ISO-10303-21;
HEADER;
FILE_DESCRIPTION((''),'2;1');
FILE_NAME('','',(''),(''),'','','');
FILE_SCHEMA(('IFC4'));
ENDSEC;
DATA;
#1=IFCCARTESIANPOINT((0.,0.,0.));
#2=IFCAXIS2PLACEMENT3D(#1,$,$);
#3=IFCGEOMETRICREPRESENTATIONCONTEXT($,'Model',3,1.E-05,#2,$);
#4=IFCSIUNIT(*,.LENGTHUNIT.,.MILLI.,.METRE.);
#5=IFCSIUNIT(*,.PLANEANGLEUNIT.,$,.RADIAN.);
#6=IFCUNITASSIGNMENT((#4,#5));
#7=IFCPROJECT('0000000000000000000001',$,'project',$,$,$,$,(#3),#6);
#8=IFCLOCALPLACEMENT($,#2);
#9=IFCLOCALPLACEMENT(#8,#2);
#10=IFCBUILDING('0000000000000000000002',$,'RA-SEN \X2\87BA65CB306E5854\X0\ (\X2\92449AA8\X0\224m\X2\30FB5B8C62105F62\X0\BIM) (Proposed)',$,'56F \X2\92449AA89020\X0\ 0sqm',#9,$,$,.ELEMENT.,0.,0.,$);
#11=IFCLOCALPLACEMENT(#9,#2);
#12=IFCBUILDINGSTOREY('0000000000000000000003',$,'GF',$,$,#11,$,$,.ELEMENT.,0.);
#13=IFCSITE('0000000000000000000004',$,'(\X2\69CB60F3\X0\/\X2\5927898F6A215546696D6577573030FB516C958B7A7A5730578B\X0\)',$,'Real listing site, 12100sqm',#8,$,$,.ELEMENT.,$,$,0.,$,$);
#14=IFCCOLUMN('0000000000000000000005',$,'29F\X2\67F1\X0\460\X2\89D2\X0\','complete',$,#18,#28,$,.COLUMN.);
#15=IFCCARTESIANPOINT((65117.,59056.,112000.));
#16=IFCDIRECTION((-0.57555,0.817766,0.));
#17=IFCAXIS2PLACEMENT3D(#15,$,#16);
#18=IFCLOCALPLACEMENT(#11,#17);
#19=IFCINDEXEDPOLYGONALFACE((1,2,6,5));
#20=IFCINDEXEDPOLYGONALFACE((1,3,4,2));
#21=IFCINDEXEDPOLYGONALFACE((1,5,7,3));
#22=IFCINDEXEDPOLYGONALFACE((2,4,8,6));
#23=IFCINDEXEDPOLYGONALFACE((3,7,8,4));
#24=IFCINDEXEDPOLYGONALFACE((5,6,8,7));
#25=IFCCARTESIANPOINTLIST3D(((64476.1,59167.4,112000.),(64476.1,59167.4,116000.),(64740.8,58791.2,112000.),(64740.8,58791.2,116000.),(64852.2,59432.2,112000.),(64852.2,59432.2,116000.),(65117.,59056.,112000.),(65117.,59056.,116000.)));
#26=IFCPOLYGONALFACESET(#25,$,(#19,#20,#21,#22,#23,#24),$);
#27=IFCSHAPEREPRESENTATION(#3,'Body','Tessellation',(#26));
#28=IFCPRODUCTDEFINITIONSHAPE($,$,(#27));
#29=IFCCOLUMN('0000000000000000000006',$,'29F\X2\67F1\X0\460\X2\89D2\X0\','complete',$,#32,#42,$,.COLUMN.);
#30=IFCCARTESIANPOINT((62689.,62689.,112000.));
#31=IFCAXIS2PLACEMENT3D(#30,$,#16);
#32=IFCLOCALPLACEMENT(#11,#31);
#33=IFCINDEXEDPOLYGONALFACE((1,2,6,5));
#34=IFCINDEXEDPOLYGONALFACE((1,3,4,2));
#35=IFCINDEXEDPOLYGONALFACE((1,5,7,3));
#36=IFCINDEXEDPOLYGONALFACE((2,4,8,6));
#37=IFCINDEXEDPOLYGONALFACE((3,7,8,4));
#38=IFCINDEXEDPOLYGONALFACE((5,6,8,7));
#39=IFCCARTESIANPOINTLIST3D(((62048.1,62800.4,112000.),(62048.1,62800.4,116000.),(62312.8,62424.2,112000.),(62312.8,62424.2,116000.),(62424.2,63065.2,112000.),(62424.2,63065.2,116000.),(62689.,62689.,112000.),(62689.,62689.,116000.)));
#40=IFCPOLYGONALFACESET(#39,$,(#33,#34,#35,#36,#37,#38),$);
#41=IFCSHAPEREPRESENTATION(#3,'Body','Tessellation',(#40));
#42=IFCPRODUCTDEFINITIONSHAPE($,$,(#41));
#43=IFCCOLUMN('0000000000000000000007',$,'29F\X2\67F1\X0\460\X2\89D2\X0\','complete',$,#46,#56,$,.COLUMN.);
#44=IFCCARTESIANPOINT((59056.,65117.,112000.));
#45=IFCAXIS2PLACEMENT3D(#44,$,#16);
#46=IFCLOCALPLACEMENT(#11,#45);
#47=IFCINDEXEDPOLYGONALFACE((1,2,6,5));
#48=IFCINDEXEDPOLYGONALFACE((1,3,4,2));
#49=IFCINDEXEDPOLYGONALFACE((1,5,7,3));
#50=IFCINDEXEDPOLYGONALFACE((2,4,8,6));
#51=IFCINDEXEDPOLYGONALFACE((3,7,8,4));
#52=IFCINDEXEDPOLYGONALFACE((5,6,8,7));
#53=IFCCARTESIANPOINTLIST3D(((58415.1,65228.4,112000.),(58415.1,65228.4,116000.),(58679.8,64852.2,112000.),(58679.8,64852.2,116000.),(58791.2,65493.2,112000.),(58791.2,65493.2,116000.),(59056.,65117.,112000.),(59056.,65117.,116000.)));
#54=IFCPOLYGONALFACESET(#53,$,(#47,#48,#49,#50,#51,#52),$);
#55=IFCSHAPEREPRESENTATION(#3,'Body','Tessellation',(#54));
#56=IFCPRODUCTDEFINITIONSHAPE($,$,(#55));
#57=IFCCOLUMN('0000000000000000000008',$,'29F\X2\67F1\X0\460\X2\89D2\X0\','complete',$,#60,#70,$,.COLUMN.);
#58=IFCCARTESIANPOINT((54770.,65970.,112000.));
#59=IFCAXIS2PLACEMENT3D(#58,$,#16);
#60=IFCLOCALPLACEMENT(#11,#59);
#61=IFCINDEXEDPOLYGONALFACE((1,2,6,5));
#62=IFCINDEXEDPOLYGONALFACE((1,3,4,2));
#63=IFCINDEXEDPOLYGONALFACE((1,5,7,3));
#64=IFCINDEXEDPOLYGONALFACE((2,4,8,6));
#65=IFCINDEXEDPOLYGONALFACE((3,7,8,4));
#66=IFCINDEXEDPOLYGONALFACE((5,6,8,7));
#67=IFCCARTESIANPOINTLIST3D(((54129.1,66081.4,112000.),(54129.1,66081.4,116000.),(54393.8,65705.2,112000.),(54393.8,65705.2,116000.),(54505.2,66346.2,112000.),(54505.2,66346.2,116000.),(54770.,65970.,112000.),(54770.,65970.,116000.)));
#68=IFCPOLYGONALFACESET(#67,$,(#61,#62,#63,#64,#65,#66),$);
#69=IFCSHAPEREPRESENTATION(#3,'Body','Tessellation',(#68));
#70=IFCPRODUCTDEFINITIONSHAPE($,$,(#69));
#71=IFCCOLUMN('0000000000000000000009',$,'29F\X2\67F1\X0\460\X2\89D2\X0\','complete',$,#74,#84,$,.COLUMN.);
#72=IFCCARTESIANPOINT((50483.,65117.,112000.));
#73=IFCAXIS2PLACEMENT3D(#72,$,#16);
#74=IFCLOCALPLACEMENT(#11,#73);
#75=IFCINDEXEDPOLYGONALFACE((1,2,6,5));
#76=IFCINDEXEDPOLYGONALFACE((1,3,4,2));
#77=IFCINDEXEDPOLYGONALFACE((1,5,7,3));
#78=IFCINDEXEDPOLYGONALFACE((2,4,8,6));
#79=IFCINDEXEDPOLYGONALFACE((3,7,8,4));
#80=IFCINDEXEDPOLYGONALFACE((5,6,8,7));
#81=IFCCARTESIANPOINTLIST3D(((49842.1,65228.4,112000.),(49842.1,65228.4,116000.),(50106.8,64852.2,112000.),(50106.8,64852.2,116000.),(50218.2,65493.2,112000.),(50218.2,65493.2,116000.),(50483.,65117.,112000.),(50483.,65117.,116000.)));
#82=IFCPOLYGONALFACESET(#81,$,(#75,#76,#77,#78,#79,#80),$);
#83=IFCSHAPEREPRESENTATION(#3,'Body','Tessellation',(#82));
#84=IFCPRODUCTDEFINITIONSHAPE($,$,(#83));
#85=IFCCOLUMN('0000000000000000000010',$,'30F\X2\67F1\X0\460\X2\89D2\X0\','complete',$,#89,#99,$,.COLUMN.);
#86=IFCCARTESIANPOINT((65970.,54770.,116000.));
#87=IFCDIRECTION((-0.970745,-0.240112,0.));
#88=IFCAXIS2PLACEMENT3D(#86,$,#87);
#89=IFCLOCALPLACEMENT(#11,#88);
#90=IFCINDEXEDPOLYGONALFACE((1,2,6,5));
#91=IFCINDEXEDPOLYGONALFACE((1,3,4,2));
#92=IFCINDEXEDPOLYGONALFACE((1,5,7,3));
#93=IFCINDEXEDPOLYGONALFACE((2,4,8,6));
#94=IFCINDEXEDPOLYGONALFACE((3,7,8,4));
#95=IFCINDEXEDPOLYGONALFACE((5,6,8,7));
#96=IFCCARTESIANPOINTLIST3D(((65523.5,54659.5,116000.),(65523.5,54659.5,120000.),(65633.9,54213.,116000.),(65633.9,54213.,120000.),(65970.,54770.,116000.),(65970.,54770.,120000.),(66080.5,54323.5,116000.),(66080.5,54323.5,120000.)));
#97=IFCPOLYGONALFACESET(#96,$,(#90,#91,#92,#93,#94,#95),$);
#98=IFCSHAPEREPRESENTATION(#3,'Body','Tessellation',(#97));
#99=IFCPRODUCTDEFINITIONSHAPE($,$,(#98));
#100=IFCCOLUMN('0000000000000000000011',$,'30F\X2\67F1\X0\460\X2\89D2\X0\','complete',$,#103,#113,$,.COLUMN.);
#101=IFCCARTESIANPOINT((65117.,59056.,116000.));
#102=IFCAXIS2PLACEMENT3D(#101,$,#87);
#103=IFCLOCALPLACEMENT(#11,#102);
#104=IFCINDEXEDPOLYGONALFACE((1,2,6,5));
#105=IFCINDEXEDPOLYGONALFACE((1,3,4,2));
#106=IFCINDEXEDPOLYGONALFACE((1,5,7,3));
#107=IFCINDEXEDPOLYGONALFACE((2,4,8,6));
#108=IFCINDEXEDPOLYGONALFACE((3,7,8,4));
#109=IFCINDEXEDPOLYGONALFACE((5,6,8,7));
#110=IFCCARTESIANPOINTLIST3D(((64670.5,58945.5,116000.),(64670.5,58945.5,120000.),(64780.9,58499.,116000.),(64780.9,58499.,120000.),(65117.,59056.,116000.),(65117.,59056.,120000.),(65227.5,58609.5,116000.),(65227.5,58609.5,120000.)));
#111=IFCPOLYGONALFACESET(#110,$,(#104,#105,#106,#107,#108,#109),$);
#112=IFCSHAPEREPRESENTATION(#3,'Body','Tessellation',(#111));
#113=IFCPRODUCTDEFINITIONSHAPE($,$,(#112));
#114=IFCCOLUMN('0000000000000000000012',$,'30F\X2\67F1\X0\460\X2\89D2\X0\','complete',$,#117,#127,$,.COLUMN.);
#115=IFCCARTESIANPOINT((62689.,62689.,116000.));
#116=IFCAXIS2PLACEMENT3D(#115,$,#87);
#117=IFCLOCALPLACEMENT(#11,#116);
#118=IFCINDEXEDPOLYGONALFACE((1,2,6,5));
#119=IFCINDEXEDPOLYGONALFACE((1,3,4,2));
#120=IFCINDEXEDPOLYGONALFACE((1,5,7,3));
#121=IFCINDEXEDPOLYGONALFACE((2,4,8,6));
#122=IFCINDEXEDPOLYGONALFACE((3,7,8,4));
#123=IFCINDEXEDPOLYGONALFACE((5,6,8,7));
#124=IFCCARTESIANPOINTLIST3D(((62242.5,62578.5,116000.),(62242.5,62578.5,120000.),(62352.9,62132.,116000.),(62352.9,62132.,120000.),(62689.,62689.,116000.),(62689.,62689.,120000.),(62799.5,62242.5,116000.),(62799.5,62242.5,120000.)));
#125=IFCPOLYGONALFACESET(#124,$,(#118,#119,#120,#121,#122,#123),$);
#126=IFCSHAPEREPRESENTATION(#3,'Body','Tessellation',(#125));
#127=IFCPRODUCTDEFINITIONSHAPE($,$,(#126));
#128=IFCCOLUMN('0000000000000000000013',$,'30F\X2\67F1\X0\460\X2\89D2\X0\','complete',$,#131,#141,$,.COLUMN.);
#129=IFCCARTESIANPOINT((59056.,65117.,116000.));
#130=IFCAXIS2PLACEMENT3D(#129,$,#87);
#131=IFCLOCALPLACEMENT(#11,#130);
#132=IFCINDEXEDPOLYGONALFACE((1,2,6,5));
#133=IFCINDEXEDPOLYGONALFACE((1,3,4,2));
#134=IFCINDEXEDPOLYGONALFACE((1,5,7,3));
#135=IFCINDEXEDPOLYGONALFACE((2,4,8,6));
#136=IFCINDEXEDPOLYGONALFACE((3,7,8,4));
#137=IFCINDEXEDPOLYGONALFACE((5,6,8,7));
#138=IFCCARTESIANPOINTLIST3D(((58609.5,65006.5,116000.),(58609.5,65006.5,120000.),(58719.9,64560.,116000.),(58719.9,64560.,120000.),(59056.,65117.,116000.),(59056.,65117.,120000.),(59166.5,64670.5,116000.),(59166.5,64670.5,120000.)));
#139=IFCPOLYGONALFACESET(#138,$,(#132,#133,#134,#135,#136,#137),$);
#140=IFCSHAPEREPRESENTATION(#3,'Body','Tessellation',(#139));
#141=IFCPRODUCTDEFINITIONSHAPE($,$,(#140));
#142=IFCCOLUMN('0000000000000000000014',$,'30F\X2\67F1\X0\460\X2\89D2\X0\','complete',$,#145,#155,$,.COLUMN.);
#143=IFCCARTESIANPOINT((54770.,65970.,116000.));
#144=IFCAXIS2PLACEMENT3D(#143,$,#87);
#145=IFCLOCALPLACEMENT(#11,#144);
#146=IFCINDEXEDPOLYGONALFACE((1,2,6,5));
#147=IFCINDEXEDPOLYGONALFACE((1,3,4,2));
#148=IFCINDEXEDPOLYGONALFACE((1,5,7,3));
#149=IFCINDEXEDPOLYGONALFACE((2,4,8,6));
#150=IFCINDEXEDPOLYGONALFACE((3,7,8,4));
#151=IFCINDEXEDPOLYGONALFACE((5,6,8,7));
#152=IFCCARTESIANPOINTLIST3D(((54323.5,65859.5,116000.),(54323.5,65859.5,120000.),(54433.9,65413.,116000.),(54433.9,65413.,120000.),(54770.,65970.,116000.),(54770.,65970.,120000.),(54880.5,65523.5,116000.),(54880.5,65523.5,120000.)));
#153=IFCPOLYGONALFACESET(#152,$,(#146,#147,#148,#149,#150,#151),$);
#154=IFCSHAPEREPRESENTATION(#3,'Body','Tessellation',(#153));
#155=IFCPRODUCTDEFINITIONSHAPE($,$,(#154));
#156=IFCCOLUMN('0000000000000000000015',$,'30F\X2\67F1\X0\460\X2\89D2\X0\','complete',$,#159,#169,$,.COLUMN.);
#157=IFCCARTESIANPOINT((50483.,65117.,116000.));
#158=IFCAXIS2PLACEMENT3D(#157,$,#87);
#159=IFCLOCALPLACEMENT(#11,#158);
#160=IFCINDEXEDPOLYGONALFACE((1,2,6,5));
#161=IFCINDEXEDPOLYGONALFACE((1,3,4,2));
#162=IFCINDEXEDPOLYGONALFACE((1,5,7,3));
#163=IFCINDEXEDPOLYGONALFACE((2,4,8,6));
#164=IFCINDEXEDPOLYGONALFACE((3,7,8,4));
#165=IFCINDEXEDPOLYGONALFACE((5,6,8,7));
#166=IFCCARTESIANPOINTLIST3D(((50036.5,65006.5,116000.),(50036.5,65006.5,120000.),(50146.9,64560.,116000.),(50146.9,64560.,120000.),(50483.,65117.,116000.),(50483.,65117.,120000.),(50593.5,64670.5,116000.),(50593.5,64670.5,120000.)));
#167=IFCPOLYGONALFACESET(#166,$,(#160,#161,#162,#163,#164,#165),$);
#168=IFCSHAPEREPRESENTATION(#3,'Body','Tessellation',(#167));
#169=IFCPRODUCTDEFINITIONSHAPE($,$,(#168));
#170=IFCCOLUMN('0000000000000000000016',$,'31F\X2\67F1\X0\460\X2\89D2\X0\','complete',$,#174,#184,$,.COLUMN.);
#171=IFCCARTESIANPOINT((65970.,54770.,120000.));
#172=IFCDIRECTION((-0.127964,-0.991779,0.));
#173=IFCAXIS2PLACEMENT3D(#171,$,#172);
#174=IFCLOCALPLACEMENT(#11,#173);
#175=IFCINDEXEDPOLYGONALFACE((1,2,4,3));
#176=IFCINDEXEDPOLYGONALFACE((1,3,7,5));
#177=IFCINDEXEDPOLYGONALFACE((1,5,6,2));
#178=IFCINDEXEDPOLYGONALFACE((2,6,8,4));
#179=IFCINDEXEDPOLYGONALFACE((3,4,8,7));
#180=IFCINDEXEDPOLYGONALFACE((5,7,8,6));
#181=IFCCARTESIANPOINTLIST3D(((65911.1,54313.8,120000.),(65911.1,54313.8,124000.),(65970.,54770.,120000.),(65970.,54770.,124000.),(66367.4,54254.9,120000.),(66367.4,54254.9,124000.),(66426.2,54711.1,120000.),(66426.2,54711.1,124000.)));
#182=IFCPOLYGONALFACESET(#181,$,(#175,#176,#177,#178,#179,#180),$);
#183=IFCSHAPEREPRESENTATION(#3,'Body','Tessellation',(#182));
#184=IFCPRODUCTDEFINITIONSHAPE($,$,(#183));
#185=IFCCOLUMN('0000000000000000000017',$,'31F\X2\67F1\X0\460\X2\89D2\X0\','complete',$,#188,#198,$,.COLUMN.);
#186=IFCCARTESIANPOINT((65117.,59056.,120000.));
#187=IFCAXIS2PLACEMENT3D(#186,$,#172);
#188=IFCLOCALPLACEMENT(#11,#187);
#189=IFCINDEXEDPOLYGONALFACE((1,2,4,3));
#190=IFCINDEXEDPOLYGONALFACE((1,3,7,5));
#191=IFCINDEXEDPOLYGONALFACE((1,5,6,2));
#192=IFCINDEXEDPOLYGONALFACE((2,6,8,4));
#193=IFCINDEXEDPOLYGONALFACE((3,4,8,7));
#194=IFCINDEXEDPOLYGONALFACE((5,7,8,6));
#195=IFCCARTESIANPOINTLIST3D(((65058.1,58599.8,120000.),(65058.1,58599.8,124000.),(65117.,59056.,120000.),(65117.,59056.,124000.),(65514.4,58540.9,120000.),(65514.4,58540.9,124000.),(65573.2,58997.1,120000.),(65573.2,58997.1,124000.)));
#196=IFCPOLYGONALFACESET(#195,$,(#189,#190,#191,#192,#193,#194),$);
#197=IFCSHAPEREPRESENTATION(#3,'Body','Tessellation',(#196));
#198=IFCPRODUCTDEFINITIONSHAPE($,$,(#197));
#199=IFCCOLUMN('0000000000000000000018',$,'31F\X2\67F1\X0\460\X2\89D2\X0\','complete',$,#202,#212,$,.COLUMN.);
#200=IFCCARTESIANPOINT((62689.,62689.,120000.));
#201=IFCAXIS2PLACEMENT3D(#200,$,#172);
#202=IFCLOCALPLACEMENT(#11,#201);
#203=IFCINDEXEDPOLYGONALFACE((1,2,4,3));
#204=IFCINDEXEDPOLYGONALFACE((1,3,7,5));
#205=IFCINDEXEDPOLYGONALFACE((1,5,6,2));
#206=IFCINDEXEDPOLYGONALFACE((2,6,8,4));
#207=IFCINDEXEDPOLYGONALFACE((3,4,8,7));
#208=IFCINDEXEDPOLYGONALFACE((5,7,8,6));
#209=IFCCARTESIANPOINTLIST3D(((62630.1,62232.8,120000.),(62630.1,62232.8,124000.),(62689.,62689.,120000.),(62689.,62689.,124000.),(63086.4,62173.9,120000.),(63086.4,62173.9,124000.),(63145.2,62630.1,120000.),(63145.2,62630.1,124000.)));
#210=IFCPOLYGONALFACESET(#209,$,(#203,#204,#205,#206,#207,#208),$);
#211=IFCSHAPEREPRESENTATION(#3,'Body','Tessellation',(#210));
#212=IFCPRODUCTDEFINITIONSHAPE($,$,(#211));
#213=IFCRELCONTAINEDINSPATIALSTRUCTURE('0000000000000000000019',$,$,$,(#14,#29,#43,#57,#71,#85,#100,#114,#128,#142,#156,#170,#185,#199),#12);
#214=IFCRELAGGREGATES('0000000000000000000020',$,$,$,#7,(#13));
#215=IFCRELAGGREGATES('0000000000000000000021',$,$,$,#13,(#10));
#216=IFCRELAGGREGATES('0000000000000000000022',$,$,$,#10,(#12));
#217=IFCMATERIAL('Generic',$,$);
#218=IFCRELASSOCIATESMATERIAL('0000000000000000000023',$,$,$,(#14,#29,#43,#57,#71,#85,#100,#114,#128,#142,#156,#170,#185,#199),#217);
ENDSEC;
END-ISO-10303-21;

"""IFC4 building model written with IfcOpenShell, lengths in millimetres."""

from ifc_helpers import new_model, si_unit, frame, frame_2d, origin, place, context, project, spatial, rectangle, extrude, material, element, save


model = new_model("IFC4")

# Units and contexts
model_context = context("Model", 3, precision=1e-05, world=origin())
ifc_project = project(units=[si_unit("LENGTHUNIT", "METRE", prefix="MILLI"), si_unit("PLANEANGLEUNIT", "RADIAN")], contexts=[model_context])

# Site, building, storey
site_placement = place(None, origin())
site = spatial("IfcSite", under=ifc_project, at=site_placement, Name="(構想/大規模商業敷地・公開空地型)", ObjectType="Real listing site, 12100sqm", CompositionType="ELEMENT", RefElevation=0.0)
building_placement = place(site_placement, origin())
building = spatial("IfcBuilding", under=site, at=building_placement, Name="RA-SEN 螺旋の塔 (鉄骨224m・完成形BIM) (Proposed)", ObjectType="56F 鉄骨造 0sqm", CompositionType="ELEMENT", ElevationOfRefHeight=0.0, ElevationOfTerrain=0.0)
storey_placement = place(building_placement, origin())
storey = spatial("IfcBuildingStorey", under=building, at=storey_placement, Name="GF", CompositionType="ELEMENT", Elevation=0.0)

# Columns
ifc_material = material(Name="Generic")
column_1_placement = place(storey_placement, frame((65117.0, 59056.0, 112000.0), x_axis=(-0.57555, 0.817766, 0.0)))
element("IfcColumn", 1, at=column_1_placement, inside=storey, material=ifc_material, Name="29F柱460角", Description="complete", PredefinedType="COLUMN", context=model_context, shape_type="SweptSolid", body=[
    extrude(rectangle(XDim=460.0, YDim=460.0, at=frame_2d((230.0, 230.0))), frame((65117.0, 59056.0, 112000.0), x_axis=(-0.57555, 0.817766, 0.0)), (0.0, 0.0, 1.0), 4000.0),
])
column_2_placement = place(storey_placement, frame((62689.0, 62689.0, 112000.0), x_axis=(-0.57555, 0.817766, 0.0)))
element("IfcColumn", 2, at=column_2_placement, inside=storey, material=ifc_material, Name="29F柱460角", Description="complete", PredefinedType="COLUMN", context=model_context, shape_type="SweptSolid", body=[
    extrude(rectangle(XDim=460.0, YDim=460.0, at=frame_2d((230.0, 230.0))), frame((62689.0, 62689.0, 112000.0), x_axis=(-0.57555, 0.817766, 0.0)), (0.0, 0.0, 1.0), 4000.0),
])
column_3_placement = place(storey_placement, frame((59056.0, 65117.0, 112000.0), x_axis=(-0.57555, 0.817766, 0.0)))
element("IfcColumn", 3, at=column_3_placement, inside=storey, material=ifc_material, Name="29F柱460角", Description="complete", PredefinedType="COLUMN", context=model_context, shape_type="SweptSolid", body=[
    extrude(rectangle(XDim=460.0, YDim=460.0, at=frame_2d((230.0, 230.0))), frame((59056.0, 65117.0, 112000.0), x_axis=(-0.57555, 0.817766, 0.0)), (0.0, 0.0, 1.0), 4000.0),
])
column_4_placement = place(storey_placement, frame((54770.0, 65970.0, 112000.0), x_axis=(-0.57555, 0.817766, 0.0)))
element("IfcColumn", 4, at=column_4_placement, inside=storey, material=ifc_material, Name="29F柱460角", Description="complete", PredefinedType="COLUMN", context=model_context, shape_type="SweptSolid", body=[
    extrude(rectangle(XDim=460.0, YDim=460.0, at=frame_2d((230.0, 230.0))), frame((54770.0, 65970.0, 112000.0), x_axis=(-0.57555, 0.817766, 0.0)), (0.0, 0.0, 1.0), 4000.0),
])
column_5_placement = place(storey_placement, frame((50483.0, 65117.0, 112000.0), x_axis=(-0.57555, 0.817766, 0.0)))
element("IfcColumn", 5, at=column_5_placement, inside=storey, material=ifc_material, Name="29F柱460角", Description="complete", PredefinedType="COLUMN", context=model_context, shape_type="SweptSolid", body=[
    extrude(rectangle(XDim=460.0, YDim=460.0, at=frame_2d((230.0, 230.0))), frame((50483.0, 65117.0, 112000.0), x_axis=(-0.57555, 0.817766, 0.0)), (0.0, 0.0, 1.0), 4000.0),
])
column_6_placement = place(storey_placement, frame((65970.0, 54770.0, 116000.0), x_axis=(-0.970745, -0.240112, 0.0)))
element("IfcColumn", 6, at=column_6_placement, inside=storey, material=ifc_material, Name="30F柱460角", Description="complete", PredefinedType="COLUMN", context=model_context, shape_type="SweptSolid", body=[
    extrude(rectangle(XDim=460.0, YDim=460.0, at=frame_2d((230.0, 230.0))), frame((65970.0, 54770.0, 116000.0), x_axis=(-0.970745, -0.240112, 0.0)), (0.0, 0.0, 1.0), 4000.0),
])
column_7_placement = place(storey_placement, frame((65117.0, 59056.0, 116000.0), x_axis=(-0.970745, -0.240112, 0.0)))
element("IfcColumn", 7, at=column_7_placement, inside=storey, material=ifc_material, Name="30F柱460角", Description="complete", PredefinedType="COLUMN", context=model_context, shape_type="SweptSolid", body=[
    extrude(rectangle(XDim=460.0, YDim=460.0, at=frame_2d((230.0, 230.0))), frame((65117.0, 59056.0, 116000.0), x_axis=(-0.970745, -0.240112, 0.0)), (0.0, 0.0, 1.0), 4000.0),
])
column_8_placement = place(storey_placement, frame((62689.0, 62689.0, 116000.0), x_axis=(-0.970745, -0.240112, 0.0)))
element("IfcColumn", 8, at=column_8_placement, inside=storey, material=ifc_material, Name="30F柱460角", Description="complete", PredefinedType="COLUMN", context=model_context, shape_type="SweptSolid", body=[
    extrude(rectangle(XDim=460.0, YDim=460.0, at=frame_2d((230.0, 230.0))), frame((62689.0, 62689.0, 116000.0), x_axis=(-0.970745, -0.240112, 0.0)), (0.0, 0.0, 1.0), 4000.0),
])
column_9_placement = place(storey_placement, frame((59056.0, 65117.0, 116000.0), x_axis=(-0.970745, -0.240112, 0.0)))
element("IfcColumn", 9, at=column_9_placement, inside=storey, material=ifc_material, Name="30F柱460角", Description="complete", PredefinedType="COLUMN", context=model_context, shape_type="SweptSolid", body=[
    extrude(rectangle(XDim=460.0, YDim=460.0, at=frame_2d((230.0, 230.0))), frame((59056.0, 65117.0, 116000.0), x_axis=(-0.970745, -0.240112, 0.0)), (0.0, 0.0, 1.0), 4000.0),
])
column_10_placement = place(storey_placement, frame((54770.0, 65970.0, 116000.0), x_axis=(-0.970745, -0.240112, 0.0)))
element("IfcColumn", 10, at=column_10_placement, inside=storey, material=ifc_material, Name="30F柱460角", Description="complete", PredefinedType="COLUMN", context=model_context, shape_type="SweptSolid", body=[
    extrude(rectangle(XDim=460.0, YDim=460.0, at=frame_2d((230.0, 230.0))), frame((54770.0, 65970.0, 116000.0), x_axis=(-0.970745, -0.240112, 0.0)), (0.0, 0.0, 1.0), 4000.0),
])
column_11_placement = place(storey_placement, frame((50483.0, 65117.0, 116000.0), x_axis=(-0.970745, -0.240112, 0.0)))
element("IfcColumn", 11, at=column_11_placement, inside=storey, material=ifc_material, Name="30F柱460角", Description="complete", PredefinedType="COLUMN", context=model_context, shape_type="SweptSolid", body=[
    extrude(rectangle(XDim=460.0, YDim=460.0, at=frame_2d((230.0, 230.0))), frame((50483.0, 65117.0, 116000.0), x_axis=(-0.970745, -0.240112, 0.0)), (0.0, 0.0, 1.0), 4000.0),
])
column_12_placement = place(storey_placement, frame((65970.0, 54770.0, 120000.0), x_axis=(-0.127964, -0.991779, 0.0)))
element("IfcColumn", 12, at=column_12_placement, inside=storey, material=ifc_material, Name="31F柱460角", Description="complete", PredefinedType="COLUMN", context=model_context, shape_type="SweptSolid", body=[
    extrude(rectangle(XDim=460.0, YDim=460.0, at=frame_2d((230.0, 230.0))), frame((65970.0, 54770.0, 120000.0), x_axis=(-0.127964, -0.991779, 0.0)), (0.0, 0.0, 1.0), 4000.0),
])
column_13_placement = place(storey_placement, frame((65117.0, 59056.0, 120000.0), x_axis=(-0.127964, -0.991779, 0.0)))
element("IfcColumn", 13, at=column_13_placement, inside=storey, material=ifc_material, Name="31F柱460角", Description="complete", PredefinedType="COLUMN", context=model_context, shape_type="SweptSolid", body=[
    extrude(rectangle(XDim=460.0, YDim=460.0, at=frame_2d((230.0, 230.0))), frame((65117.0, 59056.0, 120000.0), x_axis=(-0.127964, -0.991779, 0.0)), (0.0, 0.0, 1.0), 4000.0),
])
column_14_placement = place(storey_placement, frame((62689.0, 62689.0, 120000.0), x_axis=(-0.127964, -0.991779, 0.0)))
element("IfcColumn", 14, at=column_14_placement, inside=storey, material=ifc_material, Name="31F柱460角", Description="complete", PredefinedType="COLUMN", context=model_context, shape_type="SweptSolid", body=[
    extrude(rectangle(XDim=460.0, YDim=460.0, at=frame_2d((230.0, 230.0))), frame((62689.0, 62689.0, 120000.0), x_axis=(-0.127964, -0.991779, 0.0)), (0.0, 0.0, 1.0), 4000.0),
])

save(model, "model.ifc")
